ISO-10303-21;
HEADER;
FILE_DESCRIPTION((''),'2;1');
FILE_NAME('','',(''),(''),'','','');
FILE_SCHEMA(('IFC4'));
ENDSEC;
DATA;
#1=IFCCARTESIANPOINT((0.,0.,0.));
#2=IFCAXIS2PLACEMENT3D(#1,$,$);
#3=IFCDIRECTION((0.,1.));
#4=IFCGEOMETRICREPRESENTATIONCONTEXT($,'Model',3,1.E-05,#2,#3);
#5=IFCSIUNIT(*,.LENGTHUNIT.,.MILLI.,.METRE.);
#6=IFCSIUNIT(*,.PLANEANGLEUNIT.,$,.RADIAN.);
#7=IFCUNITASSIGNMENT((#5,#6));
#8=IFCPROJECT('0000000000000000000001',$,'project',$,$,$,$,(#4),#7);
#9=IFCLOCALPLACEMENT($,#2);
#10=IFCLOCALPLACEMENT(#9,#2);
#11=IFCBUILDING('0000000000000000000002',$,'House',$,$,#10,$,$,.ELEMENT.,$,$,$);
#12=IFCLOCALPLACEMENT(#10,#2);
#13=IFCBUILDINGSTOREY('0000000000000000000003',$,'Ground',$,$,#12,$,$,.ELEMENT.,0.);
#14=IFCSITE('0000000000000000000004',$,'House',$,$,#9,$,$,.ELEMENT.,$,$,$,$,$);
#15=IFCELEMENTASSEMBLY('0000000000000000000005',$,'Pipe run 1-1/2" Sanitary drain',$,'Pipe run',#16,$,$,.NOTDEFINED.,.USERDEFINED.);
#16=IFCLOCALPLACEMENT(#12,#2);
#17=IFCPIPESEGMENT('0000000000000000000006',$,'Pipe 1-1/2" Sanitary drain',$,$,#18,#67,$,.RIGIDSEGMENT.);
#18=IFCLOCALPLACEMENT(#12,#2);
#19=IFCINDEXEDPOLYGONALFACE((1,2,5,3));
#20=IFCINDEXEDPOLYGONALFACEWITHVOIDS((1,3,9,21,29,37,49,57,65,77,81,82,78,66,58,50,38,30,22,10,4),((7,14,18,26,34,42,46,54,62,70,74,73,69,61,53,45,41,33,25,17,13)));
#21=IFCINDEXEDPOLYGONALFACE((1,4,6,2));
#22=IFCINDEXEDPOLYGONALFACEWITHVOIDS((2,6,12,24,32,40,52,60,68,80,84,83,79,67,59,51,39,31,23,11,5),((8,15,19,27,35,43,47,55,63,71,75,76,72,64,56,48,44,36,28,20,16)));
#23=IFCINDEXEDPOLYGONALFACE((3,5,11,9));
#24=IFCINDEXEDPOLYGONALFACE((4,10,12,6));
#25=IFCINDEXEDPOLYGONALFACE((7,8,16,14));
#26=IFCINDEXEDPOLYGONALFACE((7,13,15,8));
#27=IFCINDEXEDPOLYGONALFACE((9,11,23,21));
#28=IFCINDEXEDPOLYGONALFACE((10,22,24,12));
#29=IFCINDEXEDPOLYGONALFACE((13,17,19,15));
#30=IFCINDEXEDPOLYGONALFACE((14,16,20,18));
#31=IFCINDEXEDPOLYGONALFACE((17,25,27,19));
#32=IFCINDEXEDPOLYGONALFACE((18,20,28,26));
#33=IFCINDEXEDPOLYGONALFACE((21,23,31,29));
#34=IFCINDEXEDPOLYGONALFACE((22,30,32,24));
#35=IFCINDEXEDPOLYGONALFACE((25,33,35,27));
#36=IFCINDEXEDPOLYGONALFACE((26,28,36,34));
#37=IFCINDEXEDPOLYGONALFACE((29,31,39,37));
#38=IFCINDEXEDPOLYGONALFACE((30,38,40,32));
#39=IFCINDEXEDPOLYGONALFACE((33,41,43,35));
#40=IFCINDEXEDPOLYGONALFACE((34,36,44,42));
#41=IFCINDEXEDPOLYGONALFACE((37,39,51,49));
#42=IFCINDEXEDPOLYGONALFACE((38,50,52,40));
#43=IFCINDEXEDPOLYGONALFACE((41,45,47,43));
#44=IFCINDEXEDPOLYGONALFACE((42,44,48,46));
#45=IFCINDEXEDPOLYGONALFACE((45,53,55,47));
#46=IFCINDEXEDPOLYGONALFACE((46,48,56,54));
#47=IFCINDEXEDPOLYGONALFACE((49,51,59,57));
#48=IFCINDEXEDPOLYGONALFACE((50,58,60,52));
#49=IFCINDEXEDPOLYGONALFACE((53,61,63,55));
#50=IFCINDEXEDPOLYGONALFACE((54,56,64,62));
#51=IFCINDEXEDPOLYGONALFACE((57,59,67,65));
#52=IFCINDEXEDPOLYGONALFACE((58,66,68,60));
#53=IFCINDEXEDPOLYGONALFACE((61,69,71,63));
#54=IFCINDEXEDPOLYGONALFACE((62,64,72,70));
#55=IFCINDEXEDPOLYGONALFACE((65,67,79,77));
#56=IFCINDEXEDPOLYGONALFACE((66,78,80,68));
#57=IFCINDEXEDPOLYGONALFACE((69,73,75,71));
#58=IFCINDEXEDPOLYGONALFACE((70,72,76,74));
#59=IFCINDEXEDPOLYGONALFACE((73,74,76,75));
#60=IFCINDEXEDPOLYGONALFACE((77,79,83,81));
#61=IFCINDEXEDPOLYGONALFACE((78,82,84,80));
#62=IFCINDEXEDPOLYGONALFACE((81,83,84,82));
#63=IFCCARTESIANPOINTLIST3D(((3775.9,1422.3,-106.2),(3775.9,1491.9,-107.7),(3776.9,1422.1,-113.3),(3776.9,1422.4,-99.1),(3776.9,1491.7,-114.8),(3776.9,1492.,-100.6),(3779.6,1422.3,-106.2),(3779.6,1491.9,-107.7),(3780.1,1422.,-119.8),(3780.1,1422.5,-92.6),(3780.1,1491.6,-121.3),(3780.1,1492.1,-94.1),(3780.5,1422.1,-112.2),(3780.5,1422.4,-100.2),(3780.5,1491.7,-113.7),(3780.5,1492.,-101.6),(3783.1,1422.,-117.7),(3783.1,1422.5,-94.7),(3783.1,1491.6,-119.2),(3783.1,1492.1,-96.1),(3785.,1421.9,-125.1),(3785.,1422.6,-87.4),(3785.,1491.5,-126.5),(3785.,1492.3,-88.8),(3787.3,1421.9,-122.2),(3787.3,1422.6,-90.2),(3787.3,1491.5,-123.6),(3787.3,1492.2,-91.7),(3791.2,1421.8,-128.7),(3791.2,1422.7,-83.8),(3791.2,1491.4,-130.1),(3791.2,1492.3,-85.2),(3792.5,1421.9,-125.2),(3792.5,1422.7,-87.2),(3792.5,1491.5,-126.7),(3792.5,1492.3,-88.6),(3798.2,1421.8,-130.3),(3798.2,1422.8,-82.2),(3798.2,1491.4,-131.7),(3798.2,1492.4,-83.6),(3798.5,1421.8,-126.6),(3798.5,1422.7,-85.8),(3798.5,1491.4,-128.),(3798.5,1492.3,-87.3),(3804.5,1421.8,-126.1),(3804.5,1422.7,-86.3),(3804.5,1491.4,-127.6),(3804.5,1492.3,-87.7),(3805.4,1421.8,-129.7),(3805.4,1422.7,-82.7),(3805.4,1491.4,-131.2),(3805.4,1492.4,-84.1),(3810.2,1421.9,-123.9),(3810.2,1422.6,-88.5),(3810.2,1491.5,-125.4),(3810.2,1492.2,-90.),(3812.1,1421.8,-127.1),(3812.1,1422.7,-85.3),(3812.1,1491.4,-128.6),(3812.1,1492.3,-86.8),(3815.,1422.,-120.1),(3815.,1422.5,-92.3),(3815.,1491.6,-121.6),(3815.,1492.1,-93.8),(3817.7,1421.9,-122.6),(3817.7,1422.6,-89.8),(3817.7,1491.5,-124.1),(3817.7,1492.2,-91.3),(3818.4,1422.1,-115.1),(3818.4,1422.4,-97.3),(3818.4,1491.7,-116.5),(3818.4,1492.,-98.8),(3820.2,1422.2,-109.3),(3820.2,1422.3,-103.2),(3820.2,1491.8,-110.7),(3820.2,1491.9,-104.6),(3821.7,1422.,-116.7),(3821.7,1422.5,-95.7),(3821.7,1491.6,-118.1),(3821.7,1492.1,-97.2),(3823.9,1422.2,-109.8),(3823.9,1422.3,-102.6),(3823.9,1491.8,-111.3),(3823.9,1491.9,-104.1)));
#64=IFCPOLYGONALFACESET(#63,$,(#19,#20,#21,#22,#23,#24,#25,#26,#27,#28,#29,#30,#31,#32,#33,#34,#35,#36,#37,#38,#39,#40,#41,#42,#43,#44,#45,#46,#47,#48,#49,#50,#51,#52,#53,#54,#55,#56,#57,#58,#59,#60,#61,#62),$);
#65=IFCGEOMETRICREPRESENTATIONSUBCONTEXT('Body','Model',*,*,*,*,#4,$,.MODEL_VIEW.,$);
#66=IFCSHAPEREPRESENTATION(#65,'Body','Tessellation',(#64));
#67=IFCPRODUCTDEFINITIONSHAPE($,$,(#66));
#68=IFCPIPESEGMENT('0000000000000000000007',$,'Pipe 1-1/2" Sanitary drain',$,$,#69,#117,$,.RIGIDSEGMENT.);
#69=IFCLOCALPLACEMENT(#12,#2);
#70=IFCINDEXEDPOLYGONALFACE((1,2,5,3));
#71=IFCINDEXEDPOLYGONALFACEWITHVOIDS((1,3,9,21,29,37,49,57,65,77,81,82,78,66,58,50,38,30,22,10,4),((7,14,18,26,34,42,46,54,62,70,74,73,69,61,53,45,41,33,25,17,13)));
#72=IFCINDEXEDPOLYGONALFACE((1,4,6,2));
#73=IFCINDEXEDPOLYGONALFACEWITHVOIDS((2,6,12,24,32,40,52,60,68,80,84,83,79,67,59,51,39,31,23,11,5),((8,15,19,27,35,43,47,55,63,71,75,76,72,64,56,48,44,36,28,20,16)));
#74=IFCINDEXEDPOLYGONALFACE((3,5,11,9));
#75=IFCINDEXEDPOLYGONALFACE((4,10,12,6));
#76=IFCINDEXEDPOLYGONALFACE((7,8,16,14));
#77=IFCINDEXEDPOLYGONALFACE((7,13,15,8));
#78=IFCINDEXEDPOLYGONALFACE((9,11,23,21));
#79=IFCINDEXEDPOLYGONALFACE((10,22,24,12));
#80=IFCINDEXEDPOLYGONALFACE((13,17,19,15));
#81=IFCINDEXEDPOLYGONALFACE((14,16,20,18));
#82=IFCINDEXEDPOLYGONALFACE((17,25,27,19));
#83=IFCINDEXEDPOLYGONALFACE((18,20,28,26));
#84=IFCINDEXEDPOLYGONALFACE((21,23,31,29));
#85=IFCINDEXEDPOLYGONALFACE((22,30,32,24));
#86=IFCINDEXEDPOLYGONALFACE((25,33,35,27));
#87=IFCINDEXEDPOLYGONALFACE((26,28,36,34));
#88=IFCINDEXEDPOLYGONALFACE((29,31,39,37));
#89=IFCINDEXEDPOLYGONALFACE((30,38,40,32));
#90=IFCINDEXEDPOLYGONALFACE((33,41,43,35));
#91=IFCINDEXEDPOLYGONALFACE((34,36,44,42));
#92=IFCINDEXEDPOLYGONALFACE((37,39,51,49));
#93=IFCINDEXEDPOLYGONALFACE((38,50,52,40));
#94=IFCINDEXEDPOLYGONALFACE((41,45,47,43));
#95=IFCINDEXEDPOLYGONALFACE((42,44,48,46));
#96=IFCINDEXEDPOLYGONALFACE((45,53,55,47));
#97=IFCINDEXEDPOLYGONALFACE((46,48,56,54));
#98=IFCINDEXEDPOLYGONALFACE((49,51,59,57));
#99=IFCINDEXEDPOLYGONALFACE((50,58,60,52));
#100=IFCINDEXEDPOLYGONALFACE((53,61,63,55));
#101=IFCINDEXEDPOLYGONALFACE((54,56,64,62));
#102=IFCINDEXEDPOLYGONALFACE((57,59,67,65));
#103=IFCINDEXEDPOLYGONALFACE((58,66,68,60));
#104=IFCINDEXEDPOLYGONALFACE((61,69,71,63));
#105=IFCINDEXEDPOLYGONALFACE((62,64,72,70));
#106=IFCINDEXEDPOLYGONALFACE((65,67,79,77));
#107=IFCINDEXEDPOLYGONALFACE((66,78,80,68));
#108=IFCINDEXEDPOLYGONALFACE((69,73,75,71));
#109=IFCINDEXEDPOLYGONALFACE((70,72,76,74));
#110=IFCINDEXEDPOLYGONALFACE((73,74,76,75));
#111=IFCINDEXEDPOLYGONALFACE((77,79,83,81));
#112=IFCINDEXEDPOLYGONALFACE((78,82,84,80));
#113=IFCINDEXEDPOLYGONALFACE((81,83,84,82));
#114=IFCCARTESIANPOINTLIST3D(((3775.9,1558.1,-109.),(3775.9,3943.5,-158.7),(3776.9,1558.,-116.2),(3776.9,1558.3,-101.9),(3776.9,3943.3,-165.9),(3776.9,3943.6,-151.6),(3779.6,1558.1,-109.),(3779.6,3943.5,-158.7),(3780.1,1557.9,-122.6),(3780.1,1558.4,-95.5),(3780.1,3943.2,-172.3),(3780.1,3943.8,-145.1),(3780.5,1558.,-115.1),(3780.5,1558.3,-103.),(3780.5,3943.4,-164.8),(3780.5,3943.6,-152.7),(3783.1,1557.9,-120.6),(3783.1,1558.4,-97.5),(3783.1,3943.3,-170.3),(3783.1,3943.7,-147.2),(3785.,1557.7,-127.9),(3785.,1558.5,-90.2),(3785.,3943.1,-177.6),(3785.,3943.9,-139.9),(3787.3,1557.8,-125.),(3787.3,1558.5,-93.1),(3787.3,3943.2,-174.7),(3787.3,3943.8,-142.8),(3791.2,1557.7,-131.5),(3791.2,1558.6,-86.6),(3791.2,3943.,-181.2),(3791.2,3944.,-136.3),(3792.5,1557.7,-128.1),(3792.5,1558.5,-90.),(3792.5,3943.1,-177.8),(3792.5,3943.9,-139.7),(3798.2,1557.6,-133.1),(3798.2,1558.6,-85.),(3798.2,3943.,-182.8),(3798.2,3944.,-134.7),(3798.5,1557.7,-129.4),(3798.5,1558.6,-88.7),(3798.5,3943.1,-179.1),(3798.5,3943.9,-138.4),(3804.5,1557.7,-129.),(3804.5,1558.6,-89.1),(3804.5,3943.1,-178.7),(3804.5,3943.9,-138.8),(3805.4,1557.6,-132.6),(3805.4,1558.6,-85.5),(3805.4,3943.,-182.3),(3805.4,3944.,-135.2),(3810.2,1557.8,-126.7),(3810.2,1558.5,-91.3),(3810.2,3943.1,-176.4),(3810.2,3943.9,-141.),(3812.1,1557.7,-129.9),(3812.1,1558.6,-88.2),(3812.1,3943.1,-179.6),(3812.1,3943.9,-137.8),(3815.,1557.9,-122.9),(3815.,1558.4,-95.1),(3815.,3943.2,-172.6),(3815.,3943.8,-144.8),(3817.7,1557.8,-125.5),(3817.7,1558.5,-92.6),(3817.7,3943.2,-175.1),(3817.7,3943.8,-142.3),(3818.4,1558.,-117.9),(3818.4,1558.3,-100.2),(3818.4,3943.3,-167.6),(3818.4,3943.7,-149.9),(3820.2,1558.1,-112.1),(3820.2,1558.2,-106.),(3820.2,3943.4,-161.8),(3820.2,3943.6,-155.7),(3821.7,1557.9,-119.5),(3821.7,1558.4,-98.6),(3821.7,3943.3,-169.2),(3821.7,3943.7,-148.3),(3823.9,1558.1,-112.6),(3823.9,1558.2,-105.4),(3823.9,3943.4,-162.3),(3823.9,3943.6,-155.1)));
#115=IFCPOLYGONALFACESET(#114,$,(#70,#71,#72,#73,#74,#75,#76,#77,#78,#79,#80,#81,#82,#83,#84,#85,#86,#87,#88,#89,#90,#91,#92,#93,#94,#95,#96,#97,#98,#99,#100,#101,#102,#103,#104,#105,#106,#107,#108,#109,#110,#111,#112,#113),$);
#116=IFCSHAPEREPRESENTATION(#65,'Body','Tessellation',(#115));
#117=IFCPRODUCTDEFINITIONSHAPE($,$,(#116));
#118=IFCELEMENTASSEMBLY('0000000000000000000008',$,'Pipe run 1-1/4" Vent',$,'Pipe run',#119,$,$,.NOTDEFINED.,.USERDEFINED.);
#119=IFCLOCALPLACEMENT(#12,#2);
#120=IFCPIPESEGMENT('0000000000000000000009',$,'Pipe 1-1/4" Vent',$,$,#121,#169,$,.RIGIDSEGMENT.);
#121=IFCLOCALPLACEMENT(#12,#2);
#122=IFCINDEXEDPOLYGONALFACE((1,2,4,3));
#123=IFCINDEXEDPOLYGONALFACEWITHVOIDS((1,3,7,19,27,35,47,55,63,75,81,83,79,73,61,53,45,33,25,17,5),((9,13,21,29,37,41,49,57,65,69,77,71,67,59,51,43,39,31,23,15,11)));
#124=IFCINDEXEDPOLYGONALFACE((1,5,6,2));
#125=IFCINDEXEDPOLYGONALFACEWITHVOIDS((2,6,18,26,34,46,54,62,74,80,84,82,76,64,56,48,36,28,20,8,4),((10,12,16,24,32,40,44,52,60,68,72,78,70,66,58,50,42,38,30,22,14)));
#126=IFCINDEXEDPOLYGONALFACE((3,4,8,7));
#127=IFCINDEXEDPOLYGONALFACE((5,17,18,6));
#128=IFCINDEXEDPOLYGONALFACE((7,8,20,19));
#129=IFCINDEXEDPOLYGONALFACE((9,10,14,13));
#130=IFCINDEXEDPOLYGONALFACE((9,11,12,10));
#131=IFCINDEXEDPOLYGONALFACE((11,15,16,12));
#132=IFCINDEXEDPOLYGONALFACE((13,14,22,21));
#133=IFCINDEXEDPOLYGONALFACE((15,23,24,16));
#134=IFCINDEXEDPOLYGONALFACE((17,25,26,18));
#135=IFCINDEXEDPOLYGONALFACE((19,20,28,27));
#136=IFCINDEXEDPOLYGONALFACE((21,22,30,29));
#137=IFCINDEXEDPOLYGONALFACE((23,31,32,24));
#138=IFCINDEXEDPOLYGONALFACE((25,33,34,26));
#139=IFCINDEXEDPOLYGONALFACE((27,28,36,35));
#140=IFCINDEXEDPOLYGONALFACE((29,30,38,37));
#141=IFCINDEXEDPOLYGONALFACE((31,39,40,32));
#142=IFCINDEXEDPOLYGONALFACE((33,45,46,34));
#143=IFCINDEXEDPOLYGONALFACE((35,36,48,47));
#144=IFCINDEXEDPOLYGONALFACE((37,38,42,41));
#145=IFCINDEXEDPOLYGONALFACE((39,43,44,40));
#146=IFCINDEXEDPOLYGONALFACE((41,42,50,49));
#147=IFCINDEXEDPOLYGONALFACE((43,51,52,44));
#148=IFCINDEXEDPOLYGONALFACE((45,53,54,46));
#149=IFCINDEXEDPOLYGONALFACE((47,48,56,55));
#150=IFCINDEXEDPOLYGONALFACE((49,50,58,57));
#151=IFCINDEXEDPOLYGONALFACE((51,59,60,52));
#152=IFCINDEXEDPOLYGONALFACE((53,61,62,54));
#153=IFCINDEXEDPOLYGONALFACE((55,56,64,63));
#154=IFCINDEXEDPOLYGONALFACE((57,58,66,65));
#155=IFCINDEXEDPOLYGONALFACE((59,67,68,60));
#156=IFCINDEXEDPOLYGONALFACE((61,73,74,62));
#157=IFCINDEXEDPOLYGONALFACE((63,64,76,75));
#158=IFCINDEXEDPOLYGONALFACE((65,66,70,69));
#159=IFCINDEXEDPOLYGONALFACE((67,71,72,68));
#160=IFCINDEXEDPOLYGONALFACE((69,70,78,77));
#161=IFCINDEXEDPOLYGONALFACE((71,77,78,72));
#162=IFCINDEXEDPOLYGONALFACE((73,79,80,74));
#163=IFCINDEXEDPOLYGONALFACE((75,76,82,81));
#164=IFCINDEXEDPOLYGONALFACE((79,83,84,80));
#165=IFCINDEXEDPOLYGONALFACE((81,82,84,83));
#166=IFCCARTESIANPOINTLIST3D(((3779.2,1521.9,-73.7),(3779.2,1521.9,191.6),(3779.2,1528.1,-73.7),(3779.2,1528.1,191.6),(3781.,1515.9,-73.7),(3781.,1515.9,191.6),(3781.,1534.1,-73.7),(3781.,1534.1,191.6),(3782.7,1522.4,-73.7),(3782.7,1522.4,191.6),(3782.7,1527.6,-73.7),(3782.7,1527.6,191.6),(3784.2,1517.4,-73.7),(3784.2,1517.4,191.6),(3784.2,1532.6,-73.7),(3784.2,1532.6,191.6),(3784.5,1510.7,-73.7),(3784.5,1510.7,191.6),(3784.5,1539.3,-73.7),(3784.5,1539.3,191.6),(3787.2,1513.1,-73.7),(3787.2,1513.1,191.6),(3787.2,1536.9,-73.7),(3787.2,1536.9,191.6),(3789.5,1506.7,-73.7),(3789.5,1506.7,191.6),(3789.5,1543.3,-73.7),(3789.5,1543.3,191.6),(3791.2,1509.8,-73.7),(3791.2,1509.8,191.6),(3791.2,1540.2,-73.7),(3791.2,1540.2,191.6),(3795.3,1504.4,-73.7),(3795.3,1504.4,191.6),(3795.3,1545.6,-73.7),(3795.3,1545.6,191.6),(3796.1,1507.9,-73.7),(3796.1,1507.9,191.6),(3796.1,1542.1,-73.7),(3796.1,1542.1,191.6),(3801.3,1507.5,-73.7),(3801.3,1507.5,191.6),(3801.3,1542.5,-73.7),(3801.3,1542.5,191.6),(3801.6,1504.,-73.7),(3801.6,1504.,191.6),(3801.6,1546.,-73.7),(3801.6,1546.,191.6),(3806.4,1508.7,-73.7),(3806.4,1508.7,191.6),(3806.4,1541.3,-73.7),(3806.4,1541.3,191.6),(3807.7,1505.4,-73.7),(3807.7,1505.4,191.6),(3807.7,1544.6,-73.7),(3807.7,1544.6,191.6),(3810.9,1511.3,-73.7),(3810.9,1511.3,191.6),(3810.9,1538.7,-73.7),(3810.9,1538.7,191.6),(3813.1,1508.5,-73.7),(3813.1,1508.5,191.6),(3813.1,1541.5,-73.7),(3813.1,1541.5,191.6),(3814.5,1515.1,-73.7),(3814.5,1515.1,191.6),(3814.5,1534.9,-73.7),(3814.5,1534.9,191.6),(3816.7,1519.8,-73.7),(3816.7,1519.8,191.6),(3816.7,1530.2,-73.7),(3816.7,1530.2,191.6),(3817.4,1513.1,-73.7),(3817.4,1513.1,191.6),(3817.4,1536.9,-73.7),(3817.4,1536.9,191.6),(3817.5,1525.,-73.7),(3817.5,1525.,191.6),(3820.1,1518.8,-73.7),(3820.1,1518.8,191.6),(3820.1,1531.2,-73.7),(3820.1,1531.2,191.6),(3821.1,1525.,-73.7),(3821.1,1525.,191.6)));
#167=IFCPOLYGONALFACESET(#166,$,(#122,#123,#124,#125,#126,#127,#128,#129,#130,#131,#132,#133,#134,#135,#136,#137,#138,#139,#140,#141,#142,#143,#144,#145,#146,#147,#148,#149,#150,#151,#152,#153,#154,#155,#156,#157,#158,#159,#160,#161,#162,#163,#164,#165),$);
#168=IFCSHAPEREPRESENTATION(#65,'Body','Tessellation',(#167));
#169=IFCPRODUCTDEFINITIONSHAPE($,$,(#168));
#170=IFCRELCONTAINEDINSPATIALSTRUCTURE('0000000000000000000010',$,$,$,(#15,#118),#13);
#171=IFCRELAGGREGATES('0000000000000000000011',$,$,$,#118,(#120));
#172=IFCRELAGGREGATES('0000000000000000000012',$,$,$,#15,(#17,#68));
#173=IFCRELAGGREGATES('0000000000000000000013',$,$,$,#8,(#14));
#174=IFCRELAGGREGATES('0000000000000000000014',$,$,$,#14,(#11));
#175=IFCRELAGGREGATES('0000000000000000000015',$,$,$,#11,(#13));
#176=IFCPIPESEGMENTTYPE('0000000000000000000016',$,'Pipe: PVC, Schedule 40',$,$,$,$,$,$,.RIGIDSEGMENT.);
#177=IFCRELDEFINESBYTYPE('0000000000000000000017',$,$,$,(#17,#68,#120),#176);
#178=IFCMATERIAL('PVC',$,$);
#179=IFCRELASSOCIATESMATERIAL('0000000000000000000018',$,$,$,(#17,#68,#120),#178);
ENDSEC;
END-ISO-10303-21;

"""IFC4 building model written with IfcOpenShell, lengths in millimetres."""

from ifc_helpers import new_model, si_unit, direction, frame, origin, origin_with_axes, origin_2d, place, context, subcontext, project, spatial, hollow_circle, extrude, material, type_object, element, aggregate, save


model = new_model("IFC4")

# Units and contexts
model_context = context("Model", 3, precision=1e-05, world=origin(), true_north=direction((0.0, 1.0)))
body_context = subcontext(model_context, "Body", "Model", "MODEL_VIEW")
ifc_project = project(units=[si_unit("LENGTHUNIT", "METRE", prefix="MILLI"), si_unit("PLANEANGLEUNIT", "RADIAN")], contexts=[model_context])

# Site, building, storey
site_placement = place(None, origin())
site = spatial("IfcSite", under=ifc_project, at=site_placement, Name="House", CompositionType="ELEMENT")
building_placement = place(site_placement, origin())
building = spatial("IfcBuilding", under=site, at=building_placement, Name="House", CompositionType="ELEMENT")
storey_placement = place(building_placement, origin())
storey = spatial("IfcBuildingStorey", under=building, at=storey_placement, Name="Ground", CompositionType="ELEMENT", Elevation=0.0)

# Shared definitions
ifc_material = material(Name="PVC")
pipe_segment_type = type_object("IfcPipeSegmentType", Name="Pipe: PVC, Schedule 40", PredefinedType="RIGIDSEGMENT")

# Element assembly, pipe segments
assembly_1_placement = place(storey_placement, origin_with_axes())
assembly_1 = element("IfcElementAssembly", 1, at=assembly_1_placement, inside=storey, Name="Pipe run 1-1/2\" Sanitary drain", ObjectType="Pipe run", AssemblyPlace="NOTDEFINED", PredefinedType="USERDEFINED")
pipe_segment_1_placement = place(storey_placement, origin_with_axes())
pipe_segment_1 = element("IfcPipeSegment", 2, at=pipe_segment_1_placement, type_object=pipe_segment_type, material=ifc_material, Name="Pipe 1-1/2\" Sanitary drain", PredefinedType="RIGIDSEGMENT", context=body_context, shape_type="SweptSolid", body=[
    extrude(hollow_circle(Radius=24.1, WallThickness=3.7, at=origin_2d()), frame((3800.0, 1422.3, -106.2), z_axis=(0.0, 0.999783, -0.020829), x_axis=(-1.0, 0.0, 0.0)), (0.0, 0.0, 1.0), 69.6),
])
pipe_segment_2_placement = place(storey_placement, origin_with_axes())
pipe_segment_2 = element("IfcPipeSegment", 3, at=pipe_segment_2_placement, type_object=pipe_segment_type, material=ifc_material, Name="Pipe 1-1/2\" Sanitary drain", PredefinedType="RIGIDSEGMENT", context=body_context, shape_type="SweptSolid", body=[
    extrude(hollow_circle(Radius=24.1, WallThickness=3.7, at=origin_2d()), frame((3800.0, 1558.1, -109.0), z_axis=(0.0, 0.999783, -0.020829), x_axis=(-1.0, 0.0, 0.0)), (0.0, 0.0, 1.0), 2385.9),
])

# Element assembly, pipe segment
assembly_2_placement = place(storey_placement, origin_with_axes())
assembly_2 = element("IfcElementAssembly", 4, at=assembly_2_placement, inside=storey, Name="Pipe run 1-1/4\" Vent", ObjectType="Pipe run", AssemblyPlace="NOTDEFINED", PredefinedType="USERDEFINED")
pipe_segment_3_placement = place(storey_placement, origin_with_axes())
pipe_segment_3 = element("IfcPipeSegment", 5, at=pipe_segment_3_placement, type_object=pipe_segment_type, material=ifc_material, Name="Pipe 1-1/4\" Vent", PredefinedType="RIGIDSEGMENT", context=body_context, shape_type="SweptSolid", body=[
    extrude(hollow_circle(Radius=21.1, WallThickness=3.6, at=origin_2d()), frame((3800.0, 1525.0, 191.6), z_axis=(0.0, 0.0, -1.0), x_axis=(1.0, 0.0, 0.0)), (0.0, 0.0, 1.0), 265.3),
])
aggregate(assembly_2, [pipe_segment_3])

aggregate(assembly_1, [pipe_segment_1, pipe_segment_2])

save(model, "model.ifc")
